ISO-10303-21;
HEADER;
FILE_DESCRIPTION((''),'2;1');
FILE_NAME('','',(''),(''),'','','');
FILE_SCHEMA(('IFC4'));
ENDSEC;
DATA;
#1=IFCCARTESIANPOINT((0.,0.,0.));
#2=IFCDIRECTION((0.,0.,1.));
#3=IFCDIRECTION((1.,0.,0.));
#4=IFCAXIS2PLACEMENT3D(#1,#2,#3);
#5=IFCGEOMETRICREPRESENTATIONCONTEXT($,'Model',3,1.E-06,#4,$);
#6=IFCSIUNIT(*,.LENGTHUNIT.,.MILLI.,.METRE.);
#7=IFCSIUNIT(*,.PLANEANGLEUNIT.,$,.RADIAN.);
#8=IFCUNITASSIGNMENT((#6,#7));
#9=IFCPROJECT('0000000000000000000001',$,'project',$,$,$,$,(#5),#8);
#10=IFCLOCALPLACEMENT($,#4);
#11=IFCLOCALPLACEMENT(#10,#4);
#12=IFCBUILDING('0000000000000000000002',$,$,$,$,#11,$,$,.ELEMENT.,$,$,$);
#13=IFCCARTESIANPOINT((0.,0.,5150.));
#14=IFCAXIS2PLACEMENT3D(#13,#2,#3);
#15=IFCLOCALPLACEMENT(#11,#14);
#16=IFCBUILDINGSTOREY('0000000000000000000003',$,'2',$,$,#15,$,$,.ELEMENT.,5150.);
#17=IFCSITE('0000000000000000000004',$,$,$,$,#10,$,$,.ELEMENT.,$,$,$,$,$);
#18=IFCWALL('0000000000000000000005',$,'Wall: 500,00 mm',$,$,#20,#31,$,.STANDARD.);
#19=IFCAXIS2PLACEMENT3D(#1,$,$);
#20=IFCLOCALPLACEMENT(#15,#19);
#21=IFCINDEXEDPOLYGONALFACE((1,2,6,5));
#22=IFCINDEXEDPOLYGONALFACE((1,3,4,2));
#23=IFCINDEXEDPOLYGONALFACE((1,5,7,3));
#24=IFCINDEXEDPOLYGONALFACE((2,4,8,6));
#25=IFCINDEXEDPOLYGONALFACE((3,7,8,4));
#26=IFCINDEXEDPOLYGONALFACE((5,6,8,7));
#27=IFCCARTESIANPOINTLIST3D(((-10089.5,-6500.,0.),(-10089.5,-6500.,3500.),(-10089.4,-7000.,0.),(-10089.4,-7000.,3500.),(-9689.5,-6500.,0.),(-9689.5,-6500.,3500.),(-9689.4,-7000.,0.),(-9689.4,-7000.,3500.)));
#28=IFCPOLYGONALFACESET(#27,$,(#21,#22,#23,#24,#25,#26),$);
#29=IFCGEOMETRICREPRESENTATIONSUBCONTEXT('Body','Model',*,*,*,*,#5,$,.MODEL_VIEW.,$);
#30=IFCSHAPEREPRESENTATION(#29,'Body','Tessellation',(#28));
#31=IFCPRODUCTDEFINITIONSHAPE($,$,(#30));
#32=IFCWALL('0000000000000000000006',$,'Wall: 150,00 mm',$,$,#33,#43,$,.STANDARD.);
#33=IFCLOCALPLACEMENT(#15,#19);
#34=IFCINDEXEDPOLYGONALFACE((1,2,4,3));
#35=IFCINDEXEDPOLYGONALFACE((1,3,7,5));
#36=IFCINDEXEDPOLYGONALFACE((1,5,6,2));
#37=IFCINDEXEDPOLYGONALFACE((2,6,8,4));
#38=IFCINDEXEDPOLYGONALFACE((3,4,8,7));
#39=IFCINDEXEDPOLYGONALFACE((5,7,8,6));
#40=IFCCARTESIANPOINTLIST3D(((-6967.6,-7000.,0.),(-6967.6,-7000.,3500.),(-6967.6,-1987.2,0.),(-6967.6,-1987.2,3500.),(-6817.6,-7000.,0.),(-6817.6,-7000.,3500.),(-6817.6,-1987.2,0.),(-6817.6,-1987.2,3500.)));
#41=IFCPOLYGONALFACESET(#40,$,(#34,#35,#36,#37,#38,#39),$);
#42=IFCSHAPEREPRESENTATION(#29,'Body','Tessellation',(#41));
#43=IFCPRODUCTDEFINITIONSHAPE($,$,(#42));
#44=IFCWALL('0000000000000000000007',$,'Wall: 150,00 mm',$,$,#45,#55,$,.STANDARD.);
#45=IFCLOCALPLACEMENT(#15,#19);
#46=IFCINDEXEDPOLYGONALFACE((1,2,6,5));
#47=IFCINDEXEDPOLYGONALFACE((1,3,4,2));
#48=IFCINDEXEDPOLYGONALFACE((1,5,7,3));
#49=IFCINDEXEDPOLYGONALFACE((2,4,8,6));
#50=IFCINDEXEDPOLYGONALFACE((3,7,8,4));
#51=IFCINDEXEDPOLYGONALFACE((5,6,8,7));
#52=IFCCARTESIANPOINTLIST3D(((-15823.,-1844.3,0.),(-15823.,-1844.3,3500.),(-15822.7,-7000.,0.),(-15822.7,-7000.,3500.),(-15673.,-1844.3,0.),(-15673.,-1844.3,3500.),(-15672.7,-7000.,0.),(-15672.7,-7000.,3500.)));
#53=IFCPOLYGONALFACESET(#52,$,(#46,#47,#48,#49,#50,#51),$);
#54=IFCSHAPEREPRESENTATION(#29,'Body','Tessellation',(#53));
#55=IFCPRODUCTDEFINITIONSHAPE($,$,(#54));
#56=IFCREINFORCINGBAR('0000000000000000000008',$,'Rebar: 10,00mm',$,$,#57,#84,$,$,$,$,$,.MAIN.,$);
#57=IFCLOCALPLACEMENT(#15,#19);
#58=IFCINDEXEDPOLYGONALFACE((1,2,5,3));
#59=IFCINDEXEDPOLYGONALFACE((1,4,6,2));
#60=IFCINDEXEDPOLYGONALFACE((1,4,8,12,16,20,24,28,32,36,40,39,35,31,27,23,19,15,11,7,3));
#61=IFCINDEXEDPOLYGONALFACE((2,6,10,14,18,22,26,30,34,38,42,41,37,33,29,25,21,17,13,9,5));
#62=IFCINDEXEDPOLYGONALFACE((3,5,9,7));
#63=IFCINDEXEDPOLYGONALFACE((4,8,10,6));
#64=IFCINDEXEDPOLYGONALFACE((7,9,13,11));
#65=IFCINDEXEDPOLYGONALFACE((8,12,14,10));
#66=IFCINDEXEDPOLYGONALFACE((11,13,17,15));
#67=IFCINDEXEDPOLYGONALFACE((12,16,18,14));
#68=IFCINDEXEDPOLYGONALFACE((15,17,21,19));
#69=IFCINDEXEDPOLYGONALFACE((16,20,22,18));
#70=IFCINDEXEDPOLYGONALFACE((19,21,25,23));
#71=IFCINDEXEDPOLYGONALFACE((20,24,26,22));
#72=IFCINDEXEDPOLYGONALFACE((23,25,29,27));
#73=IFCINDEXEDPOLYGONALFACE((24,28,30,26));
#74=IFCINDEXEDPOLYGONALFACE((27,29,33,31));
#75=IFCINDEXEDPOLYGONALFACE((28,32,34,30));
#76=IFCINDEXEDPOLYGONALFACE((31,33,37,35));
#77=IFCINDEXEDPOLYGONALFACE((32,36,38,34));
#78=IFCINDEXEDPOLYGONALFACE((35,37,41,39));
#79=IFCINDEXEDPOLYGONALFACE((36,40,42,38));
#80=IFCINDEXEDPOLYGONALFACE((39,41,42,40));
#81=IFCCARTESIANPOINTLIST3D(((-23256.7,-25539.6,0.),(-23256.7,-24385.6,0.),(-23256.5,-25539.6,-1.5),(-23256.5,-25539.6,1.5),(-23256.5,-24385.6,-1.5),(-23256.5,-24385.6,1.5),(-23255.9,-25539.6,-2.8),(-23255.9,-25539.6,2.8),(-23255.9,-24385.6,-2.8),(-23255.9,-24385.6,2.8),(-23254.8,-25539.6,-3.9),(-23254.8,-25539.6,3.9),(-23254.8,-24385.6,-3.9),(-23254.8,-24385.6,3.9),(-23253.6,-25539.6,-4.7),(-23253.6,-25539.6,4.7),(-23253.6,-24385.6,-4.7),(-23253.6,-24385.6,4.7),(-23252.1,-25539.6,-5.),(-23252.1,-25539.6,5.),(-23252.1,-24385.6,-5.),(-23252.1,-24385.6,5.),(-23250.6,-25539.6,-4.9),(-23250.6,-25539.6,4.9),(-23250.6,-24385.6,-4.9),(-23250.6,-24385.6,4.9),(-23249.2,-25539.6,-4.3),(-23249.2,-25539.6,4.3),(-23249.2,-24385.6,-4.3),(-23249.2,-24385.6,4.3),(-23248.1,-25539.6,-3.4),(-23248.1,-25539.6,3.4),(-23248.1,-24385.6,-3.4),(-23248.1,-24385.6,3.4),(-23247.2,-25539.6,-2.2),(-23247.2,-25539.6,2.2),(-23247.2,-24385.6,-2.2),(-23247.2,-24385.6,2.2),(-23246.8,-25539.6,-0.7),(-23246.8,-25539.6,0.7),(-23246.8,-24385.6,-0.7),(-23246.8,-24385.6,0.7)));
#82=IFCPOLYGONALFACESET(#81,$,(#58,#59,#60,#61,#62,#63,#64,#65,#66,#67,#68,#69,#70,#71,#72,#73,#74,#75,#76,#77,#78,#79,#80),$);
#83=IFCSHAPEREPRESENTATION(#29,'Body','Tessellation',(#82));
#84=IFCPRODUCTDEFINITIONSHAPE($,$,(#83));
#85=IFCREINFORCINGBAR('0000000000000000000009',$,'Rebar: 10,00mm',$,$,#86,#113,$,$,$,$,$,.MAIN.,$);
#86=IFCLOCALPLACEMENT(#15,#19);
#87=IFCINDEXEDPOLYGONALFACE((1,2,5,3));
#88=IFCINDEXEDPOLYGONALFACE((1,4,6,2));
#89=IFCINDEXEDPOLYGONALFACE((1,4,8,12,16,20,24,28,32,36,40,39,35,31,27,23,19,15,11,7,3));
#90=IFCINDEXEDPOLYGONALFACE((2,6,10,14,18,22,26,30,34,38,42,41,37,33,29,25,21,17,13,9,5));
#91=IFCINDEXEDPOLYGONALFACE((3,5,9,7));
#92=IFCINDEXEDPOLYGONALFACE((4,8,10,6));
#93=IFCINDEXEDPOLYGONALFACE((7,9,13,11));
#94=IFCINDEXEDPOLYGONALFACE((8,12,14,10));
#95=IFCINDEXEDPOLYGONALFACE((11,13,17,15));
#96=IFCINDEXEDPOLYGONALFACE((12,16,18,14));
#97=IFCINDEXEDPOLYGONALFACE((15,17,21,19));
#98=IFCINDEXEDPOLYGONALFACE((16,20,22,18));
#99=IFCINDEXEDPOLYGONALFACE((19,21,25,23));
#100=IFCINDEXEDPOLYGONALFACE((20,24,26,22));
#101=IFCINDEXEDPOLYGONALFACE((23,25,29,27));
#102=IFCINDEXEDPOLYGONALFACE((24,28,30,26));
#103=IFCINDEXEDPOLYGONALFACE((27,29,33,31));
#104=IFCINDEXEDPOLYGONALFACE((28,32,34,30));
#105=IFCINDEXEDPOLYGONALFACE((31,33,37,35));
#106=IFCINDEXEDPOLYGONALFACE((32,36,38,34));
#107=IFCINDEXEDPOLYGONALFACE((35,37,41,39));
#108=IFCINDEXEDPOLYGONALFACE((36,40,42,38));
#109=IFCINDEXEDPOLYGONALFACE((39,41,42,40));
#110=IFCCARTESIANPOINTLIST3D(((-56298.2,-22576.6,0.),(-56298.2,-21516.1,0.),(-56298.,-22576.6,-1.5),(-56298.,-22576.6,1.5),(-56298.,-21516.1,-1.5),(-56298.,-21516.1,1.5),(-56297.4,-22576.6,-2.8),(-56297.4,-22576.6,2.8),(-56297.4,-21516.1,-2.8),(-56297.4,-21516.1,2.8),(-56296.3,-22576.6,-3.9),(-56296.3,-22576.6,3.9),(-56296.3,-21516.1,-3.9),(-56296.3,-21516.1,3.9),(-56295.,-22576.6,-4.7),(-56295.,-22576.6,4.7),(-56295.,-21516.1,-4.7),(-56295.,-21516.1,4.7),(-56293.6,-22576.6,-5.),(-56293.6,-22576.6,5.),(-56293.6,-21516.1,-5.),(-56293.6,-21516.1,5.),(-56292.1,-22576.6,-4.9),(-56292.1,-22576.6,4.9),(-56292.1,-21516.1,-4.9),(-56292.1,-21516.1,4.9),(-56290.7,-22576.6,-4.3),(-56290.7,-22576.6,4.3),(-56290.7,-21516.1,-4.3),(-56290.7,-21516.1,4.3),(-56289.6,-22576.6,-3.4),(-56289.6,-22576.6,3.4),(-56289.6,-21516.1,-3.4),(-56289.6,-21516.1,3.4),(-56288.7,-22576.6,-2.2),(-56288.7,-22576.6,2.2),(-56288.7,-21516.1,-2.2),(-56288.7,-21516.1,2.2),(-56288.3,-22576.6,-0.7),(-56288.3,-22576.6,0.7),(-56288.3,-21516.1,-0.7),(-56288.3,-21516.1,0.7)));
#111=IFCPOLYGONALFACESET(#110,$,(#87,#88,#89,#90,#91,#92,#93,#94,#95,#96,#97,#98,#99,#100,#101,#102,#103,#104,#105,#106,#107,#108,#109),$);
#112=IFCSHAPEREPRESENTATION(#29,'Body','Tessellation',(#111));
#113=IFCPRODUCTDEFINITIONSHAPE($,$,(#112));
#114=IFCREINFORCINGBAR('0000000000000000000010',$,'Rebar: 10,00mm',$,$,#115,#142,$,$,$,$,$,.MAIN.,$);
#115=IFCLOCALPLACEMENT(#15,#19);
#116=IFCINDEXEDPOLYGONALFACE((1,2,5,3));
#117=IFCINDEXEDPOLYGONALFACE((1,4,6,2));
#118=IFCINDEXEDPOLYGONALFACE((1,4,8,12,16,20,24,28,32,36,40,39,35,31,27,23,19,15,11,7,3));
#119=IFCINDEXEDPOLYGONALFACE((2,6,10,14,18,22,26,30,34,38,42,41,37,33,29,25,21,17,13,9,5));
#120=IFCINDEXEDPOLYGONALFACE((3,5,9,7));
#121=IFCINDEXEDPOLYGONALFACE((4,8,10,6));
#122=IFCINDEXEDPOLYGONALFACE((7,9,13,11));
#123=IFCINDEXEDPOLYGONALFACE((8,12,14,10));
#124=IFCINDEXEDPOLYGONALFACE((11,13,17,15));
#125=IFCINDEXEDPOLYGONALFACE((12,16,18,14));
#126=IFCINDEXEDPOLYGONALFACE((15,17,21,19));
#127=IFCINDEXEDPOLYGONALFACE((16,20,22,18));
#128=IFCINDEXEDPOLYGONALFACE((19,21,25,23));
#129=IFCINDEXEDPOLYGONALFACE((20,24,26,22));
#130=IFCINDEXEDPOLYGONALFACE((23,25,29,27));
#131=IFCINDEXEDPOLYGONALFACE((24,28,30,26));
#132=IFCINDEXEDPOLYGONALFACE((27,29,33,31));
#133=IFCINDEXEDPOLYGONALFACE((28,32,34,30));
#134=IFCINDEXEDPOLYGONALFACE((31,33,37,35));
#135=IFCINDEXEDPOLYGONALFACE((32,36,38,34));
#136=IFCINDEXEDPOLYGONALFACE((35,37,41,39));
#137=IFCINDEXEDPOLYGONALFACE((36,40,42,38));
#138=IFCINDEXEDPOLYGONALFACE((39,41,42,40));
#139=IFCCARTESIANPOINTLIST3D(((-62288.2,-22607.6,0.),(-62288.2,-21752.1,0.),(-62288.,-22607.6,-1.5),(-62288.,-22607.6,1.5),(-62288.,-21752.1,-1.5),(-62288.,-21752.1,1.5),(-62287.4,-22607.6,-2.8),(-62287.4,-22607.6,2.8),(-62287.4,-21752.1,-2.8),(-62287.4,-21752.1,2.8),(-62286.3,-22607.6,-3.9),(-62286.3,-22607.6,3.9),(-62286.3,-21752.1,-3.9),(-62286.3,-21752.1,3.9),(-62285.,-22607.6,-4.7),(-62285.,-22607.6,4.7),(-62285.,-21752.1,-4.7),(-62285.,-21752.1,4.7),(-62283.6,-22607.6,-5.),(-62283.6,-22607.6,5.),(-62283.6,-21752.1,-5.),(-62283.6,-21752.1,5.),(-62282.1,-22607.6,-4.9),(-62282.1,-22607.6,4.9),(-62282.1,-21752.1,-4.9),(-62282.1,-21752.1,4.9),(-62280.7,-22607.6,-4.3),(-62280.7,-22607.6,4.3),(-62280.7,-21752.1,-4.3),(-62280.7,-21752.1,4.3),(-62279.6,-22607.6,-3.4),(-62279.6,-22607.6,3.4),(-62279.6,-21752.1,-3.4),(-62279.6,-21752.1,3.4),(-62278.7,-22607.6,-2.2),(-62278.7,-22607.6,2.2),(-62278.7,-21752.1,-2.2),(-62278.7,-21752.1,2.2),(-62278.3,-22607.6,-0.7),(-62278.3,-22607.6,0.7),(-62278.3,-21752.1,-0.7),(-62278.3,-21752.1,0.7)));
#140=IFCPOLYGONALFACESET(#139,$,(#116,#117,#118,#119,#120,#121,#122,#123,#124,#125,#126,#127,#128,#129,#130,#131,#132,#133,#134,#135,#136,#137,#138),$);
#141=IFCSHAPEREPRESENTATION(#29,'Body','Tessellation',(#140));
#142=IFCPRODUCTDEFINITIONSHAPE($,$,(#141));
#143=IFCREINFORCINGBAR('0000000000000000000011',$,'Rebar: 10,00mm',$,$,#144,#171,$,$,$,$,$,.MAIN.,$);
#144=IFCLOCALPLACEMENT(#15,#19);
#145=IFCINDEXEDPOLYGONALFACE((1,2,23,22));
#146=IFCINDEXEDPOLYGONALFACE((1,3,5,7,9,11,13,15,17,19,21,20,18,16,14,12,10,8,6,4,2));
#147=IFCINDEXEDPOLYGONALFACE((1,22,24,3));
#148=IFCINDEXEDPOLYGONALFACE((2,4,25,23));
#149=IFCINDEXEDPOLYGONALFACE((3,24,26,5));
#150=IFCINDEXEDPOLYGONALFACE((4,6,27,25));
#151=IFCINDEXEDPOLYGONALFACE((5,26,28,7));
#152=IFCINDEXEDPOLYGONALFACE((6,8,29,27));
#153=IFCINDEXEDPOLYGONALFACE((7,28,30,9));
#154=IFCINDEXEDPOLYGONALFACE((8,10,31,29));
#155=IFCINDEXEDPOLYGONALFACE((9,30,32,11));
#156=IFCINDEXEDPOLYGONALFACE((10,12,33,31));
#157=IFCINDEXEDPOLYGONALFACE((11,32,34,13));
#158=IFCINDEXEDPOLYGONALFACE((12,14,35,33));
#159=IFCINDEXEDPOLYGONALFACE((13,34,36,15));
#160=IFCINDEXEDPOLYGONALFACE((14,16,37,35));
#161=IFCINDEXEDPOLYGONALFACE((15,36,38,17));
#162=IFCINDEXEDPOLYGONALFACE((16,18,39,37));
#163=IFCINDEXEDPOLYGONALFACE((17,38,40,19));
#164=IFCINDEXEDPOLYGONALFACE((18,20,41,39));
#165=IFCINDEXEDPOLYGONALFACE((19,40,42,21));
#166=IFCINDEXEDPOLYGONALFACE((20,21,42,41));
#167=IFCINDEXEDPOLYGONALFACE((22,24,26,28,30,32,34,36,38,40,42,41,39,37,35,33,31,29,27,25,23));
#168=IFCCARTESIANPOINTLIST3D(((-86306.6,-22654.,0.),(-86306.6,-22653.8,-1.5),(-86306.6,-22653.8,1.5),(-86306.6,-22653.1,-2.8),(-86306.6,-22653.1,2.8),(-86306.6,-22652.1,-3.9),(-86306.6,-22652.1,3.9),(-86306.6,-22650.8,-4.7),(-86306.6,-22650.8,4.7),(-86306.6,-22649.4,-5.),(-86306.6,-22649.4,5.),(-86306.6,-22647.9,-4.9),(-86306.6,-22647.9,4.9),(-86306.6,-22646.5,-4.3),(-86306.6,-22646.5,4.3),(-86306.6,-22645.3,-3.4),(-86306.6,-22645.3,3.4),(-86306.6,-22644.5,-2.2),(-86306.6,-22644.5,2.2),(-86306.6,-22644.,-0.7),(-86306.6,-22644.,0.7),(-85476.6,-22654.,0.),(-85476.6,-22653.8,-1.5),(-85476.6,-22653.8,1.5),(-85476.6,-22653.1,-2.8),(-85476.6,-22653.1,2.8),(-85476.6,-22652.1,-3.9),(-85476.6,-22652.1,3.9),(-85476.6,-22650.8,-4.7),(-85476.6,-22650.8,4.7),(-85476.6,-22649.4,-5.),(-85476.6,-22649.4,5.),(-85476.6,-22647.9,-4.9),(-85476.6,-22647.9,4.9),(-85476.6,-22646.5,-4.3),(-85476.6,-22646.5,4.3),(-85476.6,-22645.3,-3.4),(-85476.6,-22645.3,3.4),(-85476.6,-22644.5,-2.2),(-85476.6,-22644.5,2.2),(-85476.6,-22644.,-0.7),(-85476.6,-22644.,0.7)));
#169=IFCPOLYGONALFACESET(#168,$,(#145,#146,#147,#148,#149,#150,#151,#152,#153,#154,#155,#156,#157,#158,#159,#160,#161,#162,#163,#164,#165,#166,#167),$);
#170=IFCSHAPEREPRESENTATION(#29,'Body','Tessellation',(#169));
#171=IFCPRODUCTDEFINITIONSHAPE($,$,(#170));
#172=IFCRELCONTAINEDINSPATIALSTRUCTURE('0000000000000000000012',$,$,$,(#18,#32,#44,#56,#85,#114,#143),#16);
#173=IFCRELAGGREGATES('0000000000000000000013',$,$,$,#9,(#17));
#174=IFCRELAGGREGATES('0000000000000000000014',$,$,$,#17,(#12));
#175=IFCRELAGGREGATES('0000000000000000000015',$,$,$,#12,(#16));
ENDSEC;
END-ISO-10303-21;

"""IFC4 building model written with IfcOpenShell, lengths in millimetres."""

from ifc_helpers import new_model, entity, si_unit, frame, origin_with_axes, place, context, subcontext, project, spatial, line, indexed_curve, outline, extrude, source, transform, mapped, element, save


model = new_model("IFC4")

# Units and contexts
model_context = context("Model", 3, precision=1e-06, world=origin_with_axes())
body_context = subcontext(model_context, "Body", "Model", "MODEL_VIEW")
ifc_project = project(units=[si_unit("LENGTHUNIT", "METRE", prefix="MILLI"), si_unit("PLANEANGLEUNIT", "RADIAN")], contexts=[model_context])

# Site, building, storey
site_placement = place(None, origin_with_axes())
site = spatial("IfcSite", under=ifc_project, at=site_placement, CompositionType="ELEMENT")
building_placement = place(site_placement, origin_with_axes())
building = spatial("IfcBuilding", under=site, at=building_placement, CompositionType="ELEMENT")
storey_placement = place(building_placement, frame((0.0, 0.0, 5150.0), z_axis=(0.0, 0.0, 1.0), x_axis=(1.0, 0.0, 0.0)))
storey = spatial("IfcBuildingStorey", under=building, at=storey_placement, Name="2", CompositionType="ELEMENT", Elevation=5150.0)

# Walls
wall_1_placement = place(storey_placement, frame((-9689.4, -7000.0, 0.0), z_axis=(0.0, 0.0, 1.0), x_axis=(-1.0, -0.000069, 0.0)))
element("IfcWall", 1, at=wall_1_placement, inside=storey, Name="Wall: 500,00 mm", PredefinedType="STANDARD", context=body_context, shape_type="SweptSolid", body=[
    extrude(outline(indexed_curve([(0.0, -500.0), (400.0, -500.0), (400.0, 0.0), (0.0, 0.0)], segments=[line(1, 2), line(2, 3), line(3, 4), line(4, 1)])), origin_with_axes(), (0.0, 0.0, 1.0), 3500.0),
])
wall_2_placement = place(storey_placement, frame((-6817.6, -7000.0, 0.0), z_axis=(0.0, 0.0, 1.0), x_axis=(0.0, 1.0, 0.0)))
element("IfcWall", 2, at=wall_2_placement, inside=storey, Name="Wall: 150,00 mm", PredefinedType="STANDARD", context=body_context, shape_type="SweptSolid", body=[
    extrude(outline(indexed_curve([(0.0, 0.0), (5012.8, 0.0), (5012.8, 150.0), (0.0, 150.0)], segments=[line(1, 2), line(2, 3), line(3, 4), line(4, 1)])), origin_with_axes(), (0.0, 0.0, 1.0), 3500.0),
])
wall_3_placement = place(storey_placement, frame((-15672.7, -7000.0, 0.0), z_axis=(0.0, 0.0, 1.0), x_axis=(-0.000069, 1.0, 0.0)))
element("IfcWall", 3, at=wall_3_placement, inside=storey, Name="Wall: 150,00 mm", PredefinedType="STANDARD", context=body_context, shape_type="SweptSolid", body=[
    extrude(outline(indexed_curve([(0.0, 0.0), (5155.7, 0.0), (5155.7, 150.0), (0.0, 150.0)], segments=[line(1, 2), line(2, 3), line(3, 4), line(4, 1)])), origin_with_axes(), (0.0, 0.0, 1.0), 3500.0),
])

# Reinforcing bars
shared_shape_1 = source(origin_with_axes(), body_context, "Body", "AdvancedSweptSolid", [
    entity("IfcSweptDiskSolid", entity("IfcIndexedPolyCurve", entity("IfcCartesianPointList3D", [[0.0, 0.0, 0.0], [1154.0, 0.0, 0.0]]), [entity("IfcLineIndex", [1, 2])]), 5.0),
])
reinforcing_bar_1_placement = place(storey_placement, origin_with_axes())
element("IfcReinforcingBar", 4, at=reinforcing_bar_1_placement, inside=storey, Name="Rebar: 10,00mm", PredefinedType="MAIN", context=body_context, shape_type="MappedRepresentation", body=[
    mapped(shared_shape_1, transform((-23251.7, -25539.6, 0.0), x_axis=(0.0, 1.0, 0.0), y_axis=(-1.0, 0.0, 0.0), z_axis=(0.0, 0.0, 1.0), scale=1.0)),
])
shared_shape_2 = source(origin_with_axes(), body_context, "Body", "AdvancedSweptSolid", [
    entity("IfcSweptDiskSolid", entity("IfcIndexedPolyCurve", entity("IfcCartesianPointList3D", [[0.0, 0.0, 0.0], [1060.6, 0.0, 0.0]]), [entity("IfcLineIndex", [1, 2])]), 5.0),
])
reinforcing_bar_2_placement = place(storey_placement, origin_with_axes())
element("IfcReinforcingBar", 5, at=reinforcing_bar_2_placement, inside=storey, Name="Rebar: 10,00mm", PredefinedType="MAIN", context=body_context, shape_type="MappedRepresentation", body=[
    mapped(shared_shape_2, transform((-56293.2, -22576.6, 0.0), x_axis=(0.0, 1.0, 0.0), y_axis=(-1.0, 0.0, 0.0), z_axis=(0.0, 0.0, 1.0), scale=1.0)),
])
shared_shape_3 = source(origin_with_axes(), body_context, "Body", "AdvancedSweptSolid", [
    entity("IfcSweptDiskSolid", entity("IfcIndexedPolyCurve", entity("IfcCartesianPointList3D", [[0.0, 0.0, 0.0], [855.4, 0.0, 0.0]]), [entity("IfcLineIndex", [1, 2])]), 5.0),
])
reinforcing_bar_3_placement = place(storey_placement, origin_with_axes())
element("IfcReinforcingBar", 6, at=reinforcing_bar_3_placement, inside=storey, Name="Rebar: 10,00mm", PredefinedType="MAIN", context=body_context, shape_type="MappedRepresentation", body=[
    mapped(shared_shape_3, transform((-62283.2, -22607.6, 0.0), x_axis=(0.0, 1.0, 0.0), y_axis=(-1.0, 0.0, 0.0), z_axis=(0.0, 0.0, 1.0), scale=1.0)),
])
shared_shape_4 = source(origin_with_axes(), body_context, "Body", "AdvancedSweptSolid", [
    entity("IfcSweptDiskSolid", entity("IfcIndexedPolyCurve", entity("IfcCartesianPointList3D", [[0.0, 0.0, 0.0], [830.0, 0.0, 0.0]]), [entity("IfcLineIndex", [1, 2])]), 5.0),
])
reinforcing_bar_4_placement = place(storey_placement, origin_with_axes())
element("IfcReinforcingBar", 7, at=reinforcing_bar_4_placement, inside=storey, Name="Rebar: 10,00mm", PredefinedType="MAIN", context=body_context, shape_type="MappedRepresentation", body=[
    mapped(shared_shape_4, transform((-85476.6, -22649.0, 0.0), x_axis=(-1.0, 0.0, 0.0), y_axis=(0.0, -1.0, 0.0), z_axis=(0.0, 0.0, 1.0), scale=1.0)),
])

save(model, "model.ifc")
